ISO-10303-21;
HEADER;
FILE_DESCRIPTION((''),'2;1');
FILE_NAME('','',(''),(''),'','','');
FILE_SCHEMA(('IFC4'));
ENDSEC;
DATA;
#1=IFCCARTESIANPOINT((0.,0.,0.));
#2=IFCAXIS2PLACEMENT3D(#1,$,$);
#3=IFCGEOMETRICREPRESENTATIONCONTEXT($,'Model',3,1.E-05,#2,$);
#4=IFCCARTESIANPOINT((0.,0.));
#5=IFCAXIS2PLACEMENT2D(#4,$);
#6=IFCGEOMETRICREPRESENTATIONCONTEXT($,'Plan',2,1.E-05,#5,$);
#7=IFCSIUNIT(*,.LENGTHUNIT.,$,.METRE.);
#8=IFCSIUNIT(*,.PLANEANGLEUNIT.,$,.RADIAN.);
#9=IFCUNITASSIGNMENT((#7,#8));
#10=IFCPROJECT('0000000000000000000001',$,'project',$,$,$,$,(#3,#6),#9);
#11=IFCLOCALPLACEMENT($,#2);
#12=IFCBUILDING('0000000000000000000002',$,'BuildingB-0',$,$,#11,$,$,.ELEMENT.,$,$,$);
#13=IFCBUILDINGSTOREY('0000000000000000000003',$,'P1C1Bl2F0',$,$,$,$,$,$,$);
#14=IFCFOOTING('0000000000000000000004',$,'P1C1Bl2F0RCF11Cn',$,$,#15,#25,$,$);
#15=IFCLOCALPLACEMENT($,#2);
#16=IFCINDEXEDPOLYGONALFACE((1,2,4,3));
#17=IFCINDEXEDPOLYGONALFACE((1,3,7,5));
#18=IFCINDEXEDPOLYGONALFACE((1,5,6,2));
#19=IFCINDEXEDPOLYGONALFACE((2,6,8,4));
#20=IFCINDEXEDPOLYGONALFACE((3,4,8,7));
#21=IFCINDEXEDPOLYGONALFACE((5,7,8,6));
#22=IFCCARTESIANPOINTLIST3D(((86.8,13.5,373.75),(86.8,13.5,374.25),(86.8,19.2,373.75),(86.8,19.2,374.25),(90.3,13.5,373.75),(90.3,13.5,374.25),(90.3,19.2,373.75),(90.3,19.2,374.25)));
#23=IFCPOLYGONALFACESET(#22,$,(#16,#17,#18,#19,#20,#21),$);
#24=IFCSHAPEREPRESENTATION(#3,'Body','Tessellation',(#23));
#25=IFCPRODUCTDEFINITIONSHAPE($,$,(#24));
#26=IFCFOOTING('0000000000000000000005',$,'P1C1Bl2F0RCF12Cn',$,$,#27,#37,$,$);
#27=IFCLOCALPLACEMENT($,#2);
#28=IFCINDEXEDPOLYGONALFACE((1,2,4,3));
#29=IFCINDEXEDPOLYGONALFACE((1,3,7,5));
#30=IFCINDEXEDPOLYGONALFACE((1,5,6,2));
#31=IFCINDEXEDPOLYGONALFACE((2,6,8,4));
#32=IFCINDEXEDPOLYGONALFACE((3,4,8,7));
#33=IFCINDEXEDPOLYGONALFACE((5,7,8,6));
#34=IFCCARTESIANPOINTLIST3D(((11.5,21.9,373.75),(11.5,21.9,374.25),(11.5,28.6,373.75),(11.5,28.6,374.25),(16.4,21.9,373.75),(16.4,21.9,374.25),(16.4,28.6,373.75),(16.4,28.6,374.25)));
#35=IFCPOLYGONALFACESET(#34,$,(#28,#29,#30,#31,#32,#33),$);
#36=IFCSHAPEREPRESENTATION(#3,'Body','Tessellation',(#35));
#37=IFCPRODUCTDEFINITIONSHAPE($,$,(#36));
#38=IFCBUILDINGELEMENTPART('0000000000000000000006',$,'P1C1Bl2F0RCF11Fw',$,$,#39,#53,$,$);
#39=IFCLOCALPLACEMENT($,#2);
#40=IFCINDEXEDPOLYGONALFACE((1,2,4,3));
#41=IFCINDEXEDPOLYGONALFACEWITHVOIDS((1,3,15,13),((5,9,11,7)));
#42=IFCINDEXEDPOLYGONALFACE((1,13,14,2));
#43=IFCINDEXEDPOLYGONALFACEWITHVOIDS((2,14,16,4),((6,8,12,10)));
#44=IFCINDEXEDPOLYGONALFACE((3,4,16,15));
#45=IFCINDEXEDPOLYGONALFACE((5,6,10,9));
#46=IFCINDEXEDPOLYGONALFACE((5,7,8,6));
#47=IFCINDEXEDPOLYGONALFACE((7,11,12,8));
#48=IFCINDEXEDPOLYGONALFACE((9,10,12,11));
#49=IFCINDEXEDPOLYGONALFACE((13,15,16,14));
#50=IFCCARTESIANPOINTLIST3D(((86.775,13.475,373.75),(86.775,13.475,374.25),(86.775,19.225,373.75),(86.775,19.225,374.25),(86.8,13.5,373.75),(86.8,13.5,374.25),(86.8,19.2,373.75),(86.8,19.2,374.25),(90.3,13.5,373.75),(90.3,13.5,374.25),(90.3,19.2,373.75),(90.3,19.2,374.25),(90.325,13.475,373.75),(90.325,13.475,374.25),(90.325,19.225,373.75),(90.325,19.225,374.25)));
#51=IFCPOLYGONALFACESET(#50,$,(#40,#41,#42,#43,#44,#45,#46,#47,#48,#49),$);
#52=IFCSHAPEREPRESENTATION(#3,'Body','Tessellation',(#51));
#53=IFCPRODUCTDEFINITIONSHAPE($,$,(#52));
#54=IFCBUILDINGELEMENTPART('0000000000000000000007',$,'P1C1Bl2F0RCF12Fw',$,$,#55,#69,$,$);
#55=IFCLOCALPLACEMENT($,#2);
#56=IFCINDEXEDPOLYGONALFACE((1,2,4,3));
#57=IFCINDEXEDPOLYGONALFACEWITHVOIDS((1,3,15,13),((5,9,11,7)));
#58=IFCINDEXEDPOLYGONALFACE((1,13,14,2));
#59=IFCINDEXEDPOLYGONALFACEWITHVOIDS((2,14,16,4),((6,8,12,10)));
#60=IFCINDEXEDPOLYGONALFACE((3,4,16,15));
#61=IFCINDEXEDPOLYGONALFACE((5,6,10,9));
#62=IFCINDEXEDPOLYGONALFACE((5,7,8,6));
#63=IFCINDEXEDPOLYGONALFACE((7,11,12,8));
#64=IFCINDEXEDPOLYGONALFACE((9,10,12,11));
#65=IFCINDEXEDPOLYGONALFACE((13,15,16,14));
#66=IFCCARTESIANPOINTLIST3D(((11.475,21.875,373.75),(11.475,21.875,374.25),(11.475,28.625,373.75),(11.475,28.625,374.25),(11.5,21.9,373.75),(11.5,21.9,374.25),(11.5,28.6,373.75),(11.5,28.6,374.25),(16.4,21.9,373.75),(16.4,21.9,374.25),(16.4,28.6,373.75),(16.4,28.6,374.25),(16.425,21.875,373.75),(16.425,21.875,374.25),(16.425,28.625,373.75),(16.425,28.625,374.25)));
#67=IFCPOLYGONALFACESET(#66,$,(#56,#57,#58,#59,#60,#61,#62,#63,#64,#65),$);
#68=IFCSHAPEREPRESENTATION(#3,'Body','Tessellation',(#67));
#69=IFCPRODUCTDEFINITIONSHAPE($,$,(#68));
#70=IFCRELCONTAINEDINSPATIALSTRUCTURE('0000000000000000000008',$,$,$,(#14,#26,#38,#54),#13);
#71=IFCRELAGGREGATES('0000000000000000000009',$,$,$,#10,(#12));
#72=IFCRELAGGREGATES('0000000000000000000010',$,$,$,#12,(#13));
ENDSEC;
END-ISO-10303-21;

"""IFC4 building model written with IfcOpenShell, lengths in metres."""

from ifc_helpers import new_model, si_unit, origin, origin_2d, place, context, project, spatial, polyline, outline, extrude, element, save


model = new_model("IFC4")

# Units and contexts
model_context = context("Model", 3, precision=1e-05, world=origin())
plan_context = context("Plan", 2, precision=1e-05, world=origin_2d())
ifc_project = project(units=[si_unit("LENGTHUNIT", "METRE"), si_unit("PLANEANGLEUNIT", "RADIAN")], contexts=[model_context, plan_context])

# Building, storey
building_placement = place(None, origin())
building = spatial("IfcBuilding", under=ifc_project, at=building_placement, Name="BuildingB-0", CompositionType="ELEMENT")
storey = spatial("IfcBuildingStorey", under=building, Name="P1C1Bl2F0")

# Footings
element("IfcFooting", 1, inside=storey, Name="P1C1Bl2F0RCF11Cn", context=model_context, shape_type="SweptSolid", body=[
    extrude(outline(polyline([(86.8, 19.2, 373.75), (90.3, 19.2, 373.75), (90.3, 13.5, 373.75), (86.8, 13.5, 373.75), (86.8, 19.2, 373.75)])), None, (0.0, 0.0, 1.0), 0.5),
])
element("IfcFooting", 2, inside=storey, Name="P1C1Bl2F0RCF12Cn", context=model_context, shape_type="SweptSolid", body=[
    extrude(outline(polyline([(16.4, 21.9, 373.75), (16.4, 28.6, 373.75), (11.5, 28.6, 373.75), (11.5, 21.9, 373.75), (16.4, 21.9, 373.75)])), None, (0.0, 0.0, 1.0), 0.5),
])

# Building element part, opening
building_element_part_1 = element("IfcBuildingElementPart", 3, inside=storey, Name="P1C1Bl2F0RCF11Fw", context=model_context, shape_type="SweptSolid", body=[
    extrude(outline(polyline([(86.775, 19.225, 373.75), (90.325, 19.225, 373.75), (90.325, 13.475, 373.75), (86.775, 13.475, 373.75), (86.775, 19.225, 373.75)])), None, (0.0, 0.0, 1.0), 0.5),
])
element("IfcOpeningElement", 4, inside=storey, cuts=building_element_part_1, context=model_context, shape_type="SweptSolid", body=[
    extrude(outline(polyline([(86.8, 19.2, 373.75), (90.3, 19.2, 373.75), (90.3, 13.5, 373.75), (86.8, 13.5, 373.75), (86.8, 19.2, 373.75)])), None, (0.0, 0.0, 1.0), 0.5),
])

# Building element part, opening
building_element_part_2 = element("IfcBuildingElementPart", 5, inside=storey, Name="P1C1Bl2F0RCF12Fw", context=model_context, shape_type="SweptSolid", body=[
    extrude(outline(polyline([(16.425, 21.875, 373.75), (16.425, 28.625, 373.75), (11.475, 28.625, 373.75), (11.475, 21.875, 373.75), (16.425, 21.875, 373.75)])), None, (0.0, 0.0, 1.0), 0.5),
])
element("IfcOpeningElement", 6, inside=storey, cuts=building_element_part_2, context=model_context, shape_type="SweptSolid", body=[
    extrude(outline(polyline([(16.4, 21.9, 373.75), (16.4, 28.6, 373.75), (11.5, 28.6, 373.75), (11.5, 21.9, 373.75), (16.4, 21.9, 373.75)])), None, (0.0, 0.0, 1.0), 0.5),
])

save(model, "model.ifc")
